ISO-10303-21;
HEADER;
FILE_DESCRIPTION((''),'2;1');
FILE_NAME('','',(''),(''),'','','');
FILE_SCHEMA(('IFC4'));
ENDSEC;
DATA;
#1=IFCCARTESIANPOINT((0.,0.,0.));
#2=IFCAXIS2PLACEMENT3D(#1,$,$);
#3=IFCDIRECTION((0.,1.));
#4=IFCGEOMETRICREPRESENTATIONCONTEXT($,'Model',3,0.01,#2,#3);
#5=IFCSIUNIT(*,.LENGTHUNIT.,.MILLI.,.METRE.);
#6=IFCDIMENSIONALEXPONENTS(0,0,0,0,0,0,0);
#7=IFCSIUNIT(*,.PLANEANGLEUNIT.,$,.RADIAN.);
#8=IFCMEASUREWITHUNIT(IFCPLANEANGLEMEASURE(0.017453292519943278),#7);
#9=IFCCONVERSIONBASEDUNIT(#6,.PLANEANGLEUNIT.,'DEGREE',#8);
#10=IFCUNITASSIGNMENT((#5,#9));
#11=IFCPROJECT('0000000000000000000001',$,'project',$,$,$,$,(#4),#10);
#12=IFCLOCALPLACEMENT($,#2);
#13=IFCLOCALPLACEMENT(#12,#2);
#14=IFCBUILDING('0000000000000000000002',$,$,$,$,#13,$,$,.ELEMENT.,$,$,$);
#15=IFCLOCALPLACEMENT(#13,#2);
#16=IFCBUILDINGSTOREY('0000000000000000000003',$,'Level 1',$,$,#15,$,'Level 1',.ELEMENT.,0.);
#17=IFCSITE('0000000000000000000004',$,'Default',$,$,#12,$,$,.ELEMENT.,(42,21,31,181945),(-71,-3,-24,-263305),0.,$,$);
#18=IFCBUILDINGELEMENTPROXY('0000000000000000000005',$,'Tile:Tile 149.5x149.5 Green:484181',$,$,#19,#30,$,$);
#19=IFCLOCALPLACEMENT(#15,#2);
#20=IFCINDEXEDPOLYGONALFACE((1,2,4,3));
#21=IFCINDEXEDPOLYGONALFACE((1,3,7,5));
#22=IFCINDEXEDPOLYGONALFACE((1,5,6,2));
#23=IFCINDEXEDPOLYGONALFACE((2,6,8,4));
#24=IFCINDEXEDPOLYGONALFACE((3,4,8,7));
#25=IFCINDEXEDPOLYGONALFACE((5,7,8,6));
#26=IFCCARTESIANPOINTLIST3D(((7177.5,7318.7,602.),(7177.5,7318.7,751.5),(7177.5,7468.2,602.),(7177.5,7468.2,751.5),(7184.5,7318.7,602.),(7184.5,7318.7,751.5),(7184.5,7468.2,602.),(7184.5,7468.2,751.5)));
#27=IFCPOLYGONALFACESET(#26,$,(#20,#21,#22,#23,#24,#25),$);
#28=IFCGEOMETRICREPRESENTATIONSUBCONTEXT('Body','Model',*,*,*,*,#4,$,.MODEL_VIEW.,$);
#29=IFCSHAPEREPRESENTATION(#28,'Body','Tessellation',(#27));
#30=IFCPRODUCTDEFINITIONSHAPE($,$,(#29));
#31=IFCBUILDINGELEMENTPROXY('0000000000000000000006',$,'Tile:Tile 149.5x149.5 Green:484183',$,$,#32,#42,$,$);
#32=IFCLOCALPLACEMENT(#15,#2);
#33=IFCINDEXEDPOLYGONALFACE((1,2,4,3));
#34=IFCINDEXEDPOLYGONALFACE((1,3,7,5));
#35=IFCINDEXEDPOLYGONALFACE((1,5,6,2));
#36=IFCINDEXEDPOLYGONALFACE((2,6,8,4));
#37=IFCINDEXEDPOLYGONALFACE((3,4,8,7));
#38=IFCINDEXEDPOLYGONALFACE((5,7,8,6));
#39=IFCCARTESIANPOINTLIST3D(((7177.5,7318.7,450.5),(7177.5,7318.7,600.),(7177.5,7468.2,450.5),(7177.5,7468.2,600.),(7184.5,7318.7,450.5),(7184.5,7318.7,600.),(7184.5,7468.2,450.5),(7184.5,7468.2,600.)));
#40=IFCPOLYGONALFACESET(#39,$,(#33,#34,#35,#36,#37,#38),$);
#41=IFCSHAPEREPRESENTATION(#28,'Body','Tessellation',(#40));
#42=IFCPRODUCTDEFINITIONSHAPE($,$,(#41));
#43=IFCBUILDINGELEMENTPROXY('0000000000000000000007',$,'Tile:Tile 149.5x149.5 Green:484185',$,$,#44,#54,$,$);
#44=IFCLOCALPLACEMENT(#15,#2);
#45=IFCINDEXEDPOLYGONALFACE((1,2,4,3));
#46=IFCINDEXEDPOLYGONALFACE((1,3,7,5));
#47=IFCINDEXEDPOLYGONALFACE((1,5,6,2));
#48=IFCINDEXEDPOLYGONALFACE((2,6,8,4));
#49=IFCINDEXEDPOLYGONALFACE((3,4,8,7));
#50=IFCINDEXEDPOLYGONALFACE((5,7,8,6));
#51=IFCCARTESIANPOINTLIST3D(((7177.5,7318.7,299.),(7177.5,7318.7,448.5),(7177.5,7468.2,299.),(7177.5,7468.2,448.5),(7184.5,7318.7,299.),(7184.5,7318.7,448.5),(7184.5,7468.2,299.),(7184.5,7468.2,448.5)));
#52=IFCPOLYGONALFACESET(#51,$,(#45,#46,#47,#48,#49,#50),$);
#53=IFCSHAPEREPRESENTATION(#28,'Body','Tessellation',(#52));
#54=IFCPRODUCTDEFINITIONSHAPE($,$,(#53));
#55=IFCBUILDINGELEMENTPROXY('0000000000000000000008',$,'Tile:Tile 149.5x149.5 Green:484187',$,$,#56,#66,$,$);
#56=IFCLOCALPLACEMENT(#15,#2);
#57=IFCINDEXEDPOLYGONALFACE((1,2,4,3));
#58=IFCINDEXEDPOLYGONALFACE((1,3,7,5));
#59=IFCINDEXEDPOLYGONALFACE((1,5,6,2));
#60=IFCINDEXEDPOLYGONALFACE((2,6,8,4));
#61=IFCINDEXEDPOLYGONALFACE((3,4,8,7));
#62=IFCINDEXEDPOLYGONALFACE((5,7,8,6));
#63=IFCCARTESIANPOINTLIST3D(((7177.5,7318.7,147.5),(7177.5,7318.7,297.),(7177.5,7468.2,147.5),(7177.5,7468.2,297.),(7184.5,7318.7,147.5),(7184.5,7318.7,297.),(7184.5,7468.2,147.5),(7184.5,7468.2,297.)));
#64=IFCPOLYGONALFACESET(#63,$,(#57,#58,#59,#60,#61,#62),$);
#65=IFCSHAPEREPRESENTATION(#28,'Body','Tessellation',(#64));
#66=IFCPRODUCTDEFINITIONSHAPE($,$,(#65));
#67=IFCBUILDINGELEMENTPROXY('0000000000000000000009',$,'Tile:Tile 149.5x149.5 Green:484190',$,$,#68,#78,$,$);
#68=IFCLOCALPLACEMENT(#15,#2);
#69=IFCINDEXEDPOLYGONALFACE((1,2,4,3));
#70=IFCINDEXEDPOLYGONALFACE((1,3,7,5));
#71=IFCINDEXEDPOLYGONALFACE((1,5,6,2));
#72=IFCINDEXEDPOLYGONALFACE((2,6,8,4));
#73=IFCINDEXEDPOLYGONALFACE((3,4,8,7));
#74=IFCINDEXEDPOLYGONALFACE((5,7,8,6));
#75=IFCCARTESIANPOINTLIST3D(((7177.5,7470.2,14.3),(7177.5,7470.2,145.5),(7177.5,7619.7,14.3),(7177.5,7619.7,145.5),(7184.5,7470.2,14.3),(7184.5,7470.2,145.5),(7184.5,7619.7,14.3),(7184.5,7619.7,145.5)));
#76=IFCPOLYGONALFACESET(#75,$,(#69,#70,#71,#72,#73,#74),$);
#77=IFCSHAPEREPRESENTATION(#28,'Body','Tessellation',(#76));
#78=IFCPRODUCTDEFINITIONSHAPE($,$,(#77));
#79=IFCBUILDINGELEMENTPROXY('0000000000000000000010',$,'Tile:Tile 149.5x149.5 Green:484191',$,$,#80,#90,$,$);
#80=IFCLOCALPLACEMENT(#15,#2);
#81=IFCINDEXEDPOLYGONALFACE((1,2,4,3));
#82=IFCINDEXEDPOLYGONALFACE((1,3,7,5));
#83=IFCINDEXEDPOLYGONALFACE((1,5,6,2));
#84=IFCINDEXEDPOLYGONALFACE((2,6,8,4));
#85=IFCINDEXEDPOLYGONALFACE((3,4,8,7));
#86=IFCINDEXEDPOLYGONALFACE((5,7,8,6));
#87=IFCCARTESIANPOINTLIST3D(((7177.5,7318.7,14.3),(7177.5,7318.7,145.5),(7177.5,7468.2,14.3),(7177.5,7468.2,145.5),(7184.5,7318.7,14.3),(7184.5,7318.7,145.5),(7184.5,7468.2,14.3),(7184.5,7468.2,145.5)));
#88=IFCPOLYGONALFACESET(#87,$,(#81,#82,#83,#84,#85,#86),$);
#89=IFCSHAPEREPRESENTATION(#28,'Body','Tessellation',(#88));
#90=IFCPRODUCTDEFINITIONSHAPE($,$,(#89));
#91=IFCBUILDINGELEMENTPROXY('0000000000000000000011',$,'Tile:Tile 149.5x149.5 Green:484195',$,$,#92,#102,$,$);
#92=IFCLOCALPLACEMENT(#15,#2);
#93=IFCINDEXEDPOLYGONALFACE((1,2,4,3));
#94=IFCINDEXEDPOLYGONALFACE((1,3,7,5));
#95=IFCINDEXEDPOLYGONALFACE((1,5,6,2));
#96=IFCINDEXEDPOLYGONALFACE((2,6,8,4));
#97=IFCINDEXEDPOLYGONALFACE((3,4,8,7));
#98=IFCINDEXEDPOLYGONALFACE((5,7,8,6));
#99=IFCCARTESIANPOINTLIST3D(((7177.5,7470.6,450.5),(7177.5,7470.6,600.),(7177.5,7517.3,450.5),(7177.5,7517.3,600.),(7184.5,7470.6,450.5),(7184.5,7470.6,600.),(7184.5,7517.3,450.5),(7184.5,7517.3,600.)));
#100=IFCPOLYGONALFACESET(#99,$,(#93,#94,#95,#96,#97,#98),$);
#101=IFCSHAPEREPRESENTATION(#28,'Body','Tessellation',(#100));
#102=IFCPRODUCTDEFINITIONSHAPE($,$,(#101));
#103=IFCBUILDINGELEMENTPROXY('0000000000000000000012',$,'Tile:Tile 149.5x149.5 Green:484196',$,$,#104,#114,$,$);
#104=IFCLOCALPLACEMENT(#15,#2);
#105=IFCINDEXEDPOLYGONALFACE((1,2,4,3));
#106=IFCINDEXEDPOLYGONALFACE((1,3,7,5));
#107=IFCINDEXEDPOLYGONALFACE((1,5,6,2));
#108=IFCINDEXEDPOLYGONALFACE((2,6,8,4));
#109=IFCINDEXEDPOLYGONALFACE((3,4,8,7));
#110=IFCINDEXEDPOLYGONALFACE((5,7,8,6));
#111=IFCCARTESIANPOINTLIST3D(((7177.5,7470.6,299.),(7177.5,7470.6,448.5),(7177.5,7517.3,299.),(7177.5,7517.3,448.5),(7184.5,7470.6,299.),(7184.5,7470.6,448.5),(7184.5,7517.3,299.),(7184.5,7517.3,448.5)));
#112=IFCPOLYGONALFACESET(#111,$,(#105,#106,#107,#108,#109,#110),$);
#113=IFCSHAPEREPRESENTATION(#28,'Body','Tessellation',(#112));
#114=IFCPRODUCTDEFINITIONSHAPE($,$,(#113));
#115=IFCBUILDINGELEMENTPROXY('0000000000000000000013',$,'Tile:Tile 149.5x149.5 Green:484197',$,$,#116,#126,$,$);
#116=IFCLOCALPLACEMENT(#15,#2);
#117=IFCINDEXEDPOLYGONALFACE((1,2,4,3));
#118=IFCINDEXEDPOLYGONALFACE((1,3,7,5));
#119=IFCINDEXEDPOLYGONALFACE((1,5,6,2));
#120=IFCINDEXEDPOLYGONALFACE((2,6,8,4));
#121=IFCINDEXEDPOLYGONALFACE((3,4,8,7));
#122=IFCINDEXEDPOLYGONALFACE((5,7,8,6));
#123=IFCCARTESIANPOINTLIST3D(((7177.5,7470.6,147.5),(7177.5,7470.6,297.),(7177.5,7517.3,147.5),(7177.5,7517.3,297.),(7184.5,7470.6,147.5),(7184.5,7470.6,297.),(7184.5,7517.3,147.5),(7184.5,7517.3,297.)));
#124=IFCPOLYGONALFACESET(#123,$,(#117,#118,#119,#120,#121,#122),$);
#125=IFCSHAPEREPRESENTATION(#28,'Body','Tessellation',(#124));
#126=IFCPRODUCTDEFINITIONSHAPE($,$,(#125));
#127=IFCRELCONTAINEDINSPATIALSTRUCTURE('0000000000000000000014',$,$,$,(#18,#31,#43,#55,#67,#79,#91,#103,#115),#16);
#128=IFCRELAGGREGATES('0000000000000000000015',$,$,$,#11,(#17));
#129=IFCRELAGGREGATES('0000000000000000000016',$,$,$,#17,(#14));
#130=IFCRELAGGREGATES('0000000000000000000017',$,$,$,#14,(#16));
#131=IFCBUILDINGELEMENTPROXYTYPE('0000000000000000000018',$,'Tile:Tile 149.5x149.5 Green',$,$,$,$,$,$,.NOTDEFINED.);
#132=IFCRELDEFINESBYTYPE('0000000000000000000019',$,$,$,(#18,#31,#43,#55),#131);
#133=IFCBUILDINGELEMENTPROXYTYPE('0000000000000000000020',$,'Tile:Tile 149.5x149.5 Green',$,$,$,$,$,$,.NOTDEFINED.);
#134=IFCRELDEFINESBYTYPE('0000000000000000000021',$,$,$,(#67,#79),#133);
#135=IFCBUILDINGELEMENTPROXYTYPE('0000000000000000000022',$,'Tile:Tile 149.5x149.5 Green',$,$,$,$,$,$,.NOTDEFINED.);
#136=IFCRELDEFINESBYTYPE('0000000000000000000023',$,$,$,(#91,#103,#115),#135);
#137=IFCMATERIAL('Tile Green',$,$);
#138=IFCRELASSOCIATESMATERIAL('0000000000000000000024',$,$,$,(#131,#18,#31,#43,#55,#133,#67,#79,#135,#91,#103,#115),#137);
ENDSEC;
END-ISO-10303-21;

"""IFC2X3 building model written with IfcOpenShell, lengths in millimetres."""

from ifc_helpers import new_model, entity, si_unit, converted_unit, direction, frame, origin, origin_2d_with_axis, place, context, subcontext, project, spatial, rectangle, extrude, source, transform, mapped, material, type_object, type_shapes, element, save


model = new_model("IFC2X3")

# Units and contexts
model_context = context("Model", 3, precision=0.01, world=origin(), true_north=direction((0.0, 1.0)))
body_context = subcontext(model_context, "Body", "Model", "MODEL_VIEW")
ifc_project = project(units=[si_unit("LENGTHUNIT", "METRE", prefix="MILLI"), converted_unit("PLANEANGLEUNIT", "DEGREE", entity("IfcPlaneAngleMeasure", 0.017453292519943278), si_unit("PLANEANGLEUNIT", "RADIAN"), dimensions=[0, 0, 0, 0, 0, 0, 0])], contexts=[model_context])

# Site, building, storey
site_placement = place(None, origin())
site = spatial("IfcSite", under=ifc_project, at=site_placement, Name="Default", CompositionType="ELEMENT", RefLatitude=(42, 21, 31, 181945), RefLongitude=(-71, -3, -24, -263305), RefElevation=0.0)
building_placement = place(site_placement, origin())
building = spatial("IfcBuilding", under=site, at=building_placement, CompositionType="ELEMENT")
storey_placement = place(building_placement, origin())
storey = spatial("IfcBuildingStorey", under=building, at=storey_placement, Name="Level 1", LongName="Level 1", CompositionType="ELEMENT", Elevation=0.0)

# Building element proxies
ifc_material_1 = material(Name="Tile Green")
building_element_proxy_type_1 = type_object("IfcBuildingElementProxyType", Name="Tile:Tile 149.5x149.5 Green", PredefinedType="NOTDEFINED", material=ifc_material_1)
shared_shape_1 = source(origin(), body_context, "Body", "SweptSolid", [
    extrude(rectangle(XDim=149.5, YDim=149.5, at=origin_2d_with_axis()), frame((-74.7, -74.8, 0.0), z_axis=(0.0, 0.0, 1.0), x_axis=(0.0, -1.0, 0.0)), (0.0, 0.0, 1.0), 7.0),
])
type_shapes(building_element_proxy_type_1, [shared_shape_1])
for number, where, z_axis, x_axis, name in (
    (1, (7184.5, 7468.2, 751.5), (-1.0, 0.0, 0.0), (0.0, 0.0, 1.0), "Tile:Tile 149.5x149.5 Green:484181"),
    (2, (7184.5, 7468.2, 600.0), (-1.0, 0.0, 0.0), (0.0, 0.0, 1.0), "Tile:Tile 149.5x149.5 Green:484183"),
    (3, (7184.5, 7468.2, 448.5), (-1.0, 0.0, 0.0), (0.0, 0.0, 1.0), "Tile:Tile 149.5x149.5 Green:484185"),
    (4, (7184.5, 7468.2, 297.0), (-1.0, 0.0, 0.0), (0.0, 0.0, 1.0), "Tile:Tile 149.5x149.5 Green:484187"),
):
    element("IfcBuildingElementProxy", number, at=place(storey_placement, frame(where, z_axis=z_axis, x_axis=x_axis)), inside=storey, type_object=building_element_proxy_type_1, material=ifc_material_1, Name=name, context=body_context, shape_type="MappedRepresentation", body=[
        mapped(shared_shape_1, transform((0.0, 0.0, 0.0), scale=1.0)),
    ])
building_element_proxy_type_2 = type_object("IfcBuildingElementProxyType", Name="Tile:Tile 149.5x149.5 Green", PredefinedType="NOTDEFINED", material=ifc_material_1)
shared_shape_2 = source(origin(), body_context, "Body", "SweptSolid", [
    extrude(rectangle(XDim=131.2, YDim=149.5, at=origin_2d_with_axis()), frame((-65.6, -74.8, 0.0), z_axis=(0.0, 0.0, 1.0), x_axis=(-1.0, 0.0, 0.0)), (0.0, 0.0, 1.0), 7.0),
])
type_shapes(building_element_proxy_type_2, [shared_shape_2])
for number, where, z_axis, x_axis, name in (
    (5, (7184.5, 7619.7, 145.5), (-1.0, 0.0, 0.0), (0.0, 0.0, 1.0), "Tile:Tile 149.5x149.5 Green:484190"),
    (6, (7184.5, 7468.2, 145.5), (-1.0, 0.0, 0.0), (0.0, 0.0, 1.0), "Tile:Tile 149.5x149.5 Green:484191"),
):
    element("IfcBuildingElementProxy", number, at=place(storey_placement, frame(where, z_axis=z_axis, x_axis=x_axis)), inside=storey, type_object=building_element_proxy_type_2, material=ifc_material_1, Name=name, context=body_context, shape_type="MappedRepresentation", body=[
        mapped(shared_shape_2, transform((0.0, 0.0, 0.0), scale=1.0)),
    ])
building_element_proxy_type_3 = type_object("IfcBuildingElementProxyType", Name="Tile:Tile 149.5x149.5 Green", PredefinedType="NOTDEFINED", material=ifc_material_1)
shared_shape_3 = source(origin(), body_context, "Body", "SweptSolid", [
    extrude(rectangle(XDim=46.7, YDim=149.5, at=origin_2d_with_axis()), frame((-23.3, -74.8, 0.0), z_axis=(0.0, 0.0, 1.0), x_axis=(-1.0, 0.0, 0.0)), (0.0, 0.0, 1.0), 7.0),
])
type_shapes(building_element_proxy_type_3, [shared_shape_3])
for number, where, z_axis, x_axis, name in (
    (7, (7184.5, 7517.3, 450.5), (-1.0, 0.0, 0.0), (0.0, 1.0, 0.0), "Tile:Tile 149.5x149.5 Green:484195"),
    (8, (7184.5, 7517.3, 299.0), (-1.0, 0.0, 0.0), (0.0, 1.0, 0.0), "Tile:Tile 149.5x149.5 Green:484196"),
    (9, (7184.5, 7517.3, 147.5), (-1.0, 0.0, 0.0), (0.0, 1.0, 0.0), "Tile:Tile 149.5x149.5 Green:484197"),
):
    element("IfcBuildingElementProxy", number, at=place(storey_placement, frame(where, z_axis=z_axis, x_axis=x_axis)), inside=storey, type_object=building_element_proxy_type_3, material=ifc_material_1, Name=name, context=body_context, shape_type="MappedRepresentation", body=[
        mapped(shared_shape_3, transform((0.0, 0.0, 0.0), scale=1.0)),
    ])

save(model, "model.ifc")
